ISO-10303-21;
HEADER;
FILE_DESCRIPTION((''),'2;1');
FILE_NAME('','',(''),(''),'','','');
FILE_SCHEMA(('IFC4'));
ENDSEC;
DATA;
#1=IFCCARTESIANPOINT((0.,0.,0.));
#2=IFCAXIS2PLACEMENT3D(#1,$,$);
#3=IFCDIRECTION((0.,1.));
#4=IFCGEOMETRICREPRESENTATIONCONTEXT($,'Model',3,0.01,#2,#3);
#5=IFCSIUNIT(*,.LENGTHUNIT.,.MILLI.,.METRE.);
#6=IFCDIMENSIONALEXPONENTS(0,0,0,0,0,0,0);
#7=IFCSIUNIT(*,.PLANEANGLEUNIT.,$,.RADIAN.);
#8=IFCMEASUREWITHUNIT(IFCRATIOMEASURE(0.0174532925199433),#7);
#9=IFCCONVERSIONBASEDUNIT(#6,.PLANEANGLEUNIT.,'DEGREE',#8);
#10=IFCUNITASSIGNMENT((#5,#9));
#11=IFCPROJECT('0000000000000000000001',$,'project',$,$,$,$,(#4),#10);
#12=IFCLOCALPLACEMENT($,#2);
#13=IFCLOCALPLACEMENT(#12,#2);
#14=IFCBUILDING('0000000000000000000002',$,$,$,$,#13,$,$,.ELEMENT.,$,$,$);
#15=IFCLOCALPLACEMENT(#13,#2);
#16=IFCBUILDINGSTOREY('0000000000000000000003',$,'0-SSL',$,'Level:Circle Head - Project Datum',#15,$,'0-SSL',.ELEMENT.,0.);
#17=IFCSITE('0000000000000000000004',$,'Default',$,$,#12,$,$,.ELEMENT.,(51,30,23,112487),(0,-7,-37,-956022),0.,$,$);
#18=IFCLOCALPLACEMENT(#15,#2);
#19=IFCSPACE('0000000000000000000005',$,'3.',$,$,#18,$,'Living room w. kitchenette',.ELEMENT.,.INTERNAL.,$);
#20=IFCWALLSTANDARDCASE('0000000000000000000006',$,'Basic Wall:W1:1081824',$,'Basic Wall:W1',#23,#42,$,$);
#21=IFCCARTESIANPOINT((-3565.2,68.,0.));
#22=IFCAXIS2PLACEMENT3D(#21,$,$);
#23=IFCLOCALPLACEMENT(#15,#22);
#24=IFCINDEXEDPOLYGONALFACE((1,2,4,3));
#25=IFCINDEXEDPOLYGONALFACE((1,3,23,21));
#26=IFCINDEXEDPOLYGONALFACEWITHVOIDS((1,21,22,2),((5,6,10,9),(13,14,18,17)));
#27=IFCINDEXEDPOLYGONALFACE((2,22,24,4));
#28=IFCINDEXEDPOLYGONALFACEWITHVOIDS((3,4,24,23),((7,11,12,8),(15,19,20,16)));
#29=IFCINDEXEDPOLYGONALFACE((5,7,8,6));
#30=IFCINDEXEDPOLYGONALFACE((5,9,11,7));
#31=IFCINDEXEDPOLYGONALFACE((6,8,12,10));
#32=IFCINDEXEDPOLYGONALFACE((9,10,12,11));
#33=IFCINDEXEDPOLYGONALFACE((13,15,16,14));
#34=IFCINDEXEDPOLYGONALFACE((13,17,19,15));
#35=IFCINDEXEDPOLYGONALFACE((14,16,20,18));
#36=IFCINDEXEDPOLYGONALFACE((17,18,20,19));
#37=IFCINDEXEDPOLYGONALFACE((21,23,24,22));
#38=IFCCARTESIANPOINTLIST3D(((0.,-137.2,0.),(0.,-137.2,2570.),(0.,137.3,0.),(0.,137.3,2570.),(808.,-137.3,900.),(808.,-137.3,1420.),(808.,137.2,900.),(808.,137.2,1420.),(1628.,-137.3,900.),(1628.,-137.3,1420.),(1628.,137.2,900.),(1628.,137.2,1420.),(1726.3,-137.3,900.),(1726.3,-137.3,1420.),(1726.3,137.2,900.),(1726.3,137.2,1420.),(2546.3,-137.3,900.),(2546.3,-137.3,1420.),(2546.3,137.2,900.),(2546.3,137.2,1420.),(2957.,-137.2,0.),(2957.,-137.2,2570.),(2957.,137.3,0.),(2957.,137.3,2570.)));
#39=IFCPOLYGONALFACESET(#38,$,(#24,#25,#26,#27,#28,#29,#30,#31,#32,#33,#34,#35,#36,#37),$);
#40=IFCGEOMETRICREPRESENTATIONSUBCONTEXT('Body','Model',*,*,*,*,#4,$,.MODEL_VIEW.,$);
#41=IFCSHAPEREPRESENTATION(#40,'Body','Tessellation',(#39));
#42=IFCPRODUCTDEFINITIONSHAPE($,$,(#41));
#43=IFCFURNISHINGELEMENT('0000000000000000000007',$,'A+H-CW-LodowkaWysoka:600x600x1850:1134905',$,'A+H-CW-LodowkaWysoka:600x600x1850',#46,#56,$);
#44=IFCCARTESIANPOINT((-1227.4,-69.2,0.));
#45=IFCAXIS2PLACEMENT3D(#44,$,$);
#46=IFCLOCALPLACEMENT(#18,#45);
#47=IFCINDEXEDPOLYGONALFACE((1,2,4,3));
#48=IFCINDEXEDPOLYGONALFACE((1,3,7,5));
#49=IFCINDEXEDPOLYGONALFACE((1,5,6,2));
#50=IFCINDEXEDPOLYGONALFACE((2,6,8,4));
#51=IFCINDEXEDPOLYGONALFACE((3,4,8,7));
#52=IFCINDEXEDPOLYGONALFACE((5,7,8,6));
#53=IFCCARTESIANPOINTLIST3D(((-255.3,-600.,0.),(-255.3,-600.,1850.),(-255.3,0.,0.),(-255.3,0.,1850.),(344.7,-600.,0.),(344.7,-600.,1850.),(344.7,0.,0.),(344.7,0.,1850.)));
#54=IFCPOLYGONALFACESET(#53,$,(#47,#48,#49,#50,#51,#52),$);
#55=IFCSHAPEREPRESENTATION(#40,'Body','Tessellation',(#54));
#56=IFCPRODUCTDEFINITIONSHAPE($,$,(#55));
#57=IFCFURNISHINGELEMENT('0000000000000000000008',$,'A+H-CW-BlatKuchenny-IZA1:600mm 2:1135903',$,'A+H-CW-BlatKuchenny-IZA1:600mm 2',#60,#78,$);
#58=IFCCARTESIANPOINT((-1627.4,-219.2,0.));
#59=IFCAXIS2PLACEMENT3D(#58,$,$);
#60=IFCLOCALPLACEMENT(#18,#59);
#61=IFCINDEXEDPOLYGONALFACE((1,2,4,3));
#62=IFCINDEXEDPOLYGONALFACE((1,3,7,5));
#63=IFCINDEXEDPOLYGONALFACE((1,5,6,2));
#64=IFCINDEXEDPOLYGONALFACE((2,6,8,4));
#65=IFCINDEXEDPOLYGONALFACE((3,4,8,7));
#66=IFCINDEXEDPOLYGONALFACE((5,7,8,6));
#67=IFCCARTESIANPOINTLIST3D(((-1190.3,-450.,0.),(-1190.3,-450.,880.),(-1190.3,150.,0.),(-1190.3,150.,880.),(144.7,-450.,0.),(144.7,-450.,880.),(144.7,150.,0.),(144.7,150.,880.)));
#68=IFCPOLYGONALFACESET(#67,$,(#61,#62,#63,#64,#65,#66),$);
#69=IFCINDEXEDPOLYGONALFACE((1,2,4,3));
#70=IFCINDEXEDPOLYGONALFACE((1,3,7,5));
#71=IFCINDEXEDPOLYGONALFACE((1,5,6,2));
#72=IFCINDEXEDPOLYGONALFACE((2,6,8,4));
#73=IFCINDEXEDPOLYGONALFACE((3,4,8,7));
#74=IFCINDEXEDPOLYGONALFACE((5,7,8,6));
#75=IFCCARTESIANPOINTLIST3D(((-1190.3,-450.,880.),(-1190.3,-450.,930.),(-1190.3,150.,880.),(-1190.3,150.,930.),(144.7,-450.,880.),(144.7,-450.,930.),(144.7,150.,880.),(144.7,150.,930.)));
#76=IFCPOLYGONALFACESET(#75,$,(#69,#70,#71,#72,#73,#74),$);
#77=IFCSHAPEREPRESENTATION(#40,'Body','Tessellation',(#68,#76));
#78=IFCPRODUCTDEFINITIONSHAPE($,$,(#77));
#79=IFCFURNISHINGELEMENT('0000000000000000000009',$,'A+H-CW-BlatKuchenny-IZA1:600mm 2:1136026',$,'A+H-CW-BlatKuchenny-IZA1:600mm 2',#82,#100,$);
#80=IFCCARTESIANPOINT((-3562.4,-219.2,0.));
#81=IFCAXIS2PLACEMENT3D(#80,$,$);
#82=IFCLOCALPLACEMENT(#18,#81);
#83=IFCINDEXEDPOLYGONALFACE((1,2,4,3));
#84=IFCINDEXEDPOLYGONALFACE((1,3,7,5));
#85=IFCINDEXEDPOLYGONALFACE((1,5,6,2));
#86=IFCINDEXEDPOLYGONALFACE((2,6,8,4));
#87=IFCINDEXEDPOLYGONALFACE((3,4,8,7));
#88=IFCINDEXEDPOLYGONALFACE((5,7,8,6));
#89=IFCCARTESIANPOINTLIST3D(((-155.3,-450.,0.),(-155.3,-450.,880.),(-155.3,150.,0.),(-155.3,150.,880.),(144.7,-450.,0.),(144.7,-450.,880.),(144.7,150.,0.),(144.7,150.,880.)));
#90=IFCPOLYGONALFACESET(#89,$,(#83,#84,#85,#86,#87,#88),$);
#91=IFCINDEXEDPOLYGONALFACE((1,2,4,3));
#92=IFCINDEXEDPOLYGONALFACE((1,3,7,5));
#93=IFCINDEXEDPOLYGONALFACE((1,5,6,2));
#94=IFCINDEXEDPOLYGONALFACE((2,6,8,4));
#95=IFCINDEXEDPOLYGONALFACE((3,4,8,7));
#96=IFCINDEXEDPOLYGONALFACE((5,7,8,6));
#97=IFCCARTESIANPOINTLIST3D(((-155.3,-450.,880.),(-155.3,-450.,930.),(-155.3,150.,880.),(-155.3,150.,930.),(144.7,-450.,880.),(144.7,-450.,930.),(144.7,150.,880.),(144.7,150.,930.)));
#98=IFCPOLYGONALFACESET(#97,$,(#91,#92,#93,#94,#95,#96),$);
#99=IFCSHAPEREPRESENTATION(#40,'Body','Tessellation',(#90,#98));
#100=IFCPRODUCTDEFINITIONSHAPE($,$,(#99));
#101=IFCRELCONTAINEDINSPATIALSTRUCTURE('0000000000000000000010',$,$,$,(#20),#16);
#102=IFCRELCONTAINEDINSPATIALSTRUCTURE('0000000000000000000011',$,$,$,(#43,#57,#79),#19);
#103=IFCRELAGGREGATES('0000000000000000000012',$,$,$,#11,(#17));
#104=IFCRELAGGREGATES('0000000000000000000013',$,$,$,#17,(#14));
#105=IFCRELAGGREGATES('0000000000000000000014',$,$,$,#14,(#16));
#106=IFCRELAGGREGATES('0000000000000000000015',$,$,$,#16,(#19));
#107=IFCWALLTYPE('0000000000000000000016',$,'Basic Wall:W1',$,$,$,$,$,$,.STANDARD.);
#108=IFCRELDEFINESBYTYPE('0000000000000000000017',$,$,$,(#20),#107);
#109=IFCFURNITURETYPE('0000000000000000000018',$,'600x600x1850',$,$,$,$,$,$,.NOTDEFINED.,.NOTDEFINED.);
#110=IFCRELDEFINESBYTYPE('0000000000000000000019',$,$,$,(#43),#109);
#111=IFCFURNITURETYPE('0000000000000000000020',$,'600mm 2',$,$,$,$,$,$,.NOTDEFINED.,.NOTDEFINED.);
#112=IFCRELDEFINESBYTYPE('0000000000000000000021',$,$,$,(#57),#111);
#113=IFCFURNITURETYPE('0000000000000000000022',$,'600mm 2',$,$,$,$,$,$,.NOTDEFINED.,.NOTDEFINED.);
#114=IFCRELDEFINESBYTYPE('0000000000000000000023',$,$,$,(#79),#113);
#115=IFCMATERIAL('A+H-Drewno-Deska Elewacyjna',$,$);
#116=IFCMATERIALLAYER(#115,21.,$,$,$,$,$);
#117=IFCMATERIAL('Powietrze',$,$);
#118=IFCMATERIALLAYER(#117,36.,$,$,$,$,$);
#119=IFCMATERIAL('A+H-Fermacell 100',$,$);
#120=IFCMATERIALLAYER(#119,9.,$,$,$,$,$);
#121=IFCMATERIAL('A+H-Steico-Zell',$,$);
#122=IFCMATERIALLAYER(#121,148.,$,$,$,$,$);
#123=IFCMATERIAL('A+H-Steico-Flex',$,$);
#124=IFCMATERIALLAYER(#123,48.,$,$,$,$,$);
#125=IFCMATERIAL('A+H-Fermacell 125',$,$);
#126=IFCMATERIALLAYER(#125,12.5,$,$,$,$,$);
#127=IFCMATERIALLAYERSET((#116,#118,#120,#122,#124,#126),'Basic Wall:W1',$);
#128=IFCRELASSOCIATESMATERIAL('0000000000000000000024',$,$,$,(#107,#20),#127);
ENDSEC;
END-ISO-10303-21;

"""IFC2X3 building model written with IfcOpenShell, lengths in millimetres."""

from ifc_helpers import new_model, entity, si_unit, converted_unit, direction, frame, frame_2d, origin, origin_2d_with_axis, place, context, subcontext, project, spatial, rectangle, extrude, source, transform, mapped, material, layer, layer_set, layer_usage, type_object, type_shapes, element, save


model = new_model("IFC2X3")

# Units and contexts
model_context = context("Model", 3, precision=0.01, world=origin(), true_north=direction((0.0, 1.0)))
body_context = subcontext(model_context, "Body", "Model", "MODEL_VIEW")
ifc_project = project(units=[si_unit("LENGTHUNIT", "METRE", prefix="MILLI"), converted_unit("PLANEANGLEUNIT", "DEGREE", entity("IfcRatioMeasure", 0.0174532925199433), si_unit("PLANEANGLEUNIT", "RADIAN"), dimensions=[0, 0, 0, 0, 0, 0, 0])], contexts=[model_context])

# Site, building, storey
site_placement = place(None, origin())
site = spatial("IfcSite", under=ifc_project, at=site_placement, Name="Default", CompositionType="ELEMENT", RefLatitude=(51, 30, 23, 112487), RefLongitude=(0, -7, -37, -956022), RefElevation=0.0)
building_placement = place(site_placement, origin())
building = spatial("IfcBuilding", under=site, at=building_placement, CompositionType="ELEMENT")
storey_placement = place(building_placement, origin())
storey = spatial("IfcBuildingStorey", under=building, at=storey_placement, Name="0-SSL", ObjectType="Level:Circle Head - Project Datum", LongName="0-SSL", CompositionType="ELEMENT", Elevation=0.0)

# Shared definitions
ifc_material_1 = material(Name="A+H-Drewno-Deska Elewacyjna")
ifc_layer_1 = layer(ifc_material_1, 21.0)
ifc_material_2 = material(Name="Powietrze")
ifc_layer_2 = layer(ifc_material_2, 36.0)
ifc_material_3 = material(Name="A+H-Fermacell 100")
ifc_layer_3 = layer(ifc_material_3, 9.0)
ifc_material_4 = material(Name="A+H-Steico-Zell")
ifc_layer_4 = layer(ifc_material_4, 148.0)
ifc_material_5 = material(Name="A+H-Steico-Flex")
ifc_layer_5 = layer(ifc_material_5, 48.0)
ifc_material_6 = material(Name="A+H-Fermacell 125")
ifc_layer_6 = layer(ifc_material_6, 12.5)
ifc_layer_set_1 = layer_set([ifc_layer_1, ifc_layer_2, ifc_layer_3, ifc_layer_4, ifc_layer_5, ifc_layer_6], Name="Basic Wall:W1")
wall_type_1 = type_object("IfcWallType", Name="Basic Wall:W1", PredefinedType="STANDARD", material=ifc_layer_set_1)

# Wall, openings
ifc_layer_usage_1 = layer_usage(ifc_layer_set_1, "AXIS2", "NEGATIVE", 137.2)
wall_1_placement = place(storey_placement, frame((-3565.2, 68.0, 0.0)))
wall_1 = element("IfcWallStandardCase", 1, at=wall_1_placement, inside=storey, type_object=wall_type_1, material=ifc_layer_usage_1, Name="Basic Wall:W1:1081824", ObjectType="Basic Wall:W1", context=body_context, shape_type="SweptSolid", body=[
    extrude(rectangle(XDim=2957.0, YDim=274.5, at=frame_2d((1478.5, 0.0), x_axis=(-1.0, 0.0))), origin(), (0.0, 0.0, 1.0), 2570.0),
])
opening_1_placement = place(wall_1_placement, origin())
element("IfcOpeningElement", 2, at=opening_1_placement, cuts=wall_1, ObjectType="Opening", context=body_context, shape_type="SweptSolid", body=[
    extrude(rectangle(XDim=520.0, YDim=820.0, at=frame_2d((0.0, 0.0), x_axis=(0.0, 1.0))), frame((1218.0, -1661.2, 1160.0), z_axis=(0.0, 1.0, 0.0), x_axis=(1.0, 0.0, 0.0)), (0.0, 0.0, 1.0), 3048.0),
])
opening_2_placement = place(wall_1_placement, origin())
element("IfcOpeningElement", 3, at=opening_2_placement, cuts=wall_1, ObjectType="Opening", context=body_context, shape_type="SweptSolid", body=[
    extrude(rectangle(XDim=520.0, YDim=820.0, at=frame_2d((0.0, 0.0), x_axis=(0.0, 1.0))), frame((2136.3, -1661.2, 1160.0), z_axis=(0.0, 1.0, 0.0), x_axis=(1.0, 0.0, 0.0)), (0.0, 0.0, 1.0), 3048.0),
])

# Shared definitions
space_placement = place(storey_placement, origin())
space = spatial("IfcSpace", under=storey, at=space_placement, Name="3.", LongName="Living room w. kitchenette", CompositionType="ELEMENT", InteriorOrExteriorSpace="INTERNAL")

# Furnishing elements
furniture_type_1 = type_object("IfcFurnitureType", Name="600x600x1850")
shared_shape_1 = source(origin(), body_context, "Body", "SweptSolid", [
    extrude(rectangle(XDim=600.0, YDim=600.0, at=origin_2d_with_axis()), frame((44.7, -300.0, 0.0)), (0.0, 0.0, 1.0), 1850.0),
])
type_shapes(furniture_type_1, [shared_shape_1])
furnishing_1_placement = place(space_placement, frame((-1227.4, -69.2, 0.0)))
element("IfcFurnishingElement", 4, at=furnishing_1_placement, inside=space, type_object=furniture_type_1, Name="A+H-CW-LodowkaWysoka:600x600x1850:1134905", ObjectType="A+H-CW-LodowkaWysoka:600x600x1850", context=body_context, shape_type="MappedRepresentation", body=[
    mapped(shared_shape_1, transform((0.0, 0.0, 0.0), scale=1.0)),
])
furniture_type_2 = type_object("IfcFurnitureType", Name="600mm 2")
shared_shape_2 = source(origin(), body_context, "Body", "SweptSolid", [
    extrude(rectangle(XDim=1335.0, YDim=600.0, at=origin_2d_with_axis()), frame((-522.8, -150.0, 0.0), z_axis=(0.0, 0.0, 1.0), x_axis=(-1.0, 0.0, 0.0)), (0.0, 0.0, 1.0), 880.0),
    extrude(rectangle(XDim=1335.0, YDim=600.0, at=origin_2d_with_axis()), frame((-522.8, -150.0, 880.0), z_axis=(0.0, 0.0, 1.0), x_axis=(-1.0, 0.0, 0.0)), (0.0, 0.0, 1.0), 50.0),
])
type_shapes(furniture_type_2, [shared_shape_2])
furnishing_2_placement = place(space_placement, frame((-1627.4, -219.2, 0.0)))
element("IfcFurnishingElement", 5, at=furnishing_2_placement, inside=space, type_object=furniture_type_2, Name="A+H-CW-BlatKuchenny-IZA1:600mm 2:1135903", ObjectType="A+H-CW-BlatKuchenny-IZA1:600mm 2", context=body_context, shape_type="MappedRepresentation", body=[
    mapped(shared_shape_2, transform((0.0, 0.0, 0.0), scale=1.0)),
])
furniture_type_3 = type_object("IfcFurnitureType", Name="600mm 2")
shared_shape_3 = source(origin(), body_context, "Body", "SweptSolid", [
    extrude(rectangle(XDim=300.0, YDim=600.0, at=origin_2d_with_axis()), frame((-5.3, -150.0, 0.0), z_axis=(0.0, 0.0, 1.0), x_axis=(-1.0, 0.0, 0.0)), (0.0, 0.0, 1.0), 880.0),
    extrude(rectangle(XDim=300.0, YDim=600.0, at=origin_2d_with_axis()), frame((-5.3, -150.0, 880.0), z_axis=(0.0, 0.0, 1.0), x_axis=(-1.0, 0.0, 0.0)), (0.0, 0.0, 1.0), 50.0),
])
type_shapes(furniture_type_3, [shared_shape_3])
furnishing_3_placement = place(space_placement, frame((-3562.4, -219.2, 0.0)))
element("IfcFurnishingElement", 6, at=furnishing_3_placement, inside=space, type_object=furniture_type_3, Name="A+H-CW-BlatKuchenny-IZA1:600mm 2:1136026", ObjectType="A+H-CW-BlatKuchenny-IZA1:600mm 2", context=body_context, shape_type="MappedRepresentation", body=[
    mapped(shared_shape_3, transform((0.0, 0.0, 0.0), scale=1.0)),
])

save(model, "model.ifc")
